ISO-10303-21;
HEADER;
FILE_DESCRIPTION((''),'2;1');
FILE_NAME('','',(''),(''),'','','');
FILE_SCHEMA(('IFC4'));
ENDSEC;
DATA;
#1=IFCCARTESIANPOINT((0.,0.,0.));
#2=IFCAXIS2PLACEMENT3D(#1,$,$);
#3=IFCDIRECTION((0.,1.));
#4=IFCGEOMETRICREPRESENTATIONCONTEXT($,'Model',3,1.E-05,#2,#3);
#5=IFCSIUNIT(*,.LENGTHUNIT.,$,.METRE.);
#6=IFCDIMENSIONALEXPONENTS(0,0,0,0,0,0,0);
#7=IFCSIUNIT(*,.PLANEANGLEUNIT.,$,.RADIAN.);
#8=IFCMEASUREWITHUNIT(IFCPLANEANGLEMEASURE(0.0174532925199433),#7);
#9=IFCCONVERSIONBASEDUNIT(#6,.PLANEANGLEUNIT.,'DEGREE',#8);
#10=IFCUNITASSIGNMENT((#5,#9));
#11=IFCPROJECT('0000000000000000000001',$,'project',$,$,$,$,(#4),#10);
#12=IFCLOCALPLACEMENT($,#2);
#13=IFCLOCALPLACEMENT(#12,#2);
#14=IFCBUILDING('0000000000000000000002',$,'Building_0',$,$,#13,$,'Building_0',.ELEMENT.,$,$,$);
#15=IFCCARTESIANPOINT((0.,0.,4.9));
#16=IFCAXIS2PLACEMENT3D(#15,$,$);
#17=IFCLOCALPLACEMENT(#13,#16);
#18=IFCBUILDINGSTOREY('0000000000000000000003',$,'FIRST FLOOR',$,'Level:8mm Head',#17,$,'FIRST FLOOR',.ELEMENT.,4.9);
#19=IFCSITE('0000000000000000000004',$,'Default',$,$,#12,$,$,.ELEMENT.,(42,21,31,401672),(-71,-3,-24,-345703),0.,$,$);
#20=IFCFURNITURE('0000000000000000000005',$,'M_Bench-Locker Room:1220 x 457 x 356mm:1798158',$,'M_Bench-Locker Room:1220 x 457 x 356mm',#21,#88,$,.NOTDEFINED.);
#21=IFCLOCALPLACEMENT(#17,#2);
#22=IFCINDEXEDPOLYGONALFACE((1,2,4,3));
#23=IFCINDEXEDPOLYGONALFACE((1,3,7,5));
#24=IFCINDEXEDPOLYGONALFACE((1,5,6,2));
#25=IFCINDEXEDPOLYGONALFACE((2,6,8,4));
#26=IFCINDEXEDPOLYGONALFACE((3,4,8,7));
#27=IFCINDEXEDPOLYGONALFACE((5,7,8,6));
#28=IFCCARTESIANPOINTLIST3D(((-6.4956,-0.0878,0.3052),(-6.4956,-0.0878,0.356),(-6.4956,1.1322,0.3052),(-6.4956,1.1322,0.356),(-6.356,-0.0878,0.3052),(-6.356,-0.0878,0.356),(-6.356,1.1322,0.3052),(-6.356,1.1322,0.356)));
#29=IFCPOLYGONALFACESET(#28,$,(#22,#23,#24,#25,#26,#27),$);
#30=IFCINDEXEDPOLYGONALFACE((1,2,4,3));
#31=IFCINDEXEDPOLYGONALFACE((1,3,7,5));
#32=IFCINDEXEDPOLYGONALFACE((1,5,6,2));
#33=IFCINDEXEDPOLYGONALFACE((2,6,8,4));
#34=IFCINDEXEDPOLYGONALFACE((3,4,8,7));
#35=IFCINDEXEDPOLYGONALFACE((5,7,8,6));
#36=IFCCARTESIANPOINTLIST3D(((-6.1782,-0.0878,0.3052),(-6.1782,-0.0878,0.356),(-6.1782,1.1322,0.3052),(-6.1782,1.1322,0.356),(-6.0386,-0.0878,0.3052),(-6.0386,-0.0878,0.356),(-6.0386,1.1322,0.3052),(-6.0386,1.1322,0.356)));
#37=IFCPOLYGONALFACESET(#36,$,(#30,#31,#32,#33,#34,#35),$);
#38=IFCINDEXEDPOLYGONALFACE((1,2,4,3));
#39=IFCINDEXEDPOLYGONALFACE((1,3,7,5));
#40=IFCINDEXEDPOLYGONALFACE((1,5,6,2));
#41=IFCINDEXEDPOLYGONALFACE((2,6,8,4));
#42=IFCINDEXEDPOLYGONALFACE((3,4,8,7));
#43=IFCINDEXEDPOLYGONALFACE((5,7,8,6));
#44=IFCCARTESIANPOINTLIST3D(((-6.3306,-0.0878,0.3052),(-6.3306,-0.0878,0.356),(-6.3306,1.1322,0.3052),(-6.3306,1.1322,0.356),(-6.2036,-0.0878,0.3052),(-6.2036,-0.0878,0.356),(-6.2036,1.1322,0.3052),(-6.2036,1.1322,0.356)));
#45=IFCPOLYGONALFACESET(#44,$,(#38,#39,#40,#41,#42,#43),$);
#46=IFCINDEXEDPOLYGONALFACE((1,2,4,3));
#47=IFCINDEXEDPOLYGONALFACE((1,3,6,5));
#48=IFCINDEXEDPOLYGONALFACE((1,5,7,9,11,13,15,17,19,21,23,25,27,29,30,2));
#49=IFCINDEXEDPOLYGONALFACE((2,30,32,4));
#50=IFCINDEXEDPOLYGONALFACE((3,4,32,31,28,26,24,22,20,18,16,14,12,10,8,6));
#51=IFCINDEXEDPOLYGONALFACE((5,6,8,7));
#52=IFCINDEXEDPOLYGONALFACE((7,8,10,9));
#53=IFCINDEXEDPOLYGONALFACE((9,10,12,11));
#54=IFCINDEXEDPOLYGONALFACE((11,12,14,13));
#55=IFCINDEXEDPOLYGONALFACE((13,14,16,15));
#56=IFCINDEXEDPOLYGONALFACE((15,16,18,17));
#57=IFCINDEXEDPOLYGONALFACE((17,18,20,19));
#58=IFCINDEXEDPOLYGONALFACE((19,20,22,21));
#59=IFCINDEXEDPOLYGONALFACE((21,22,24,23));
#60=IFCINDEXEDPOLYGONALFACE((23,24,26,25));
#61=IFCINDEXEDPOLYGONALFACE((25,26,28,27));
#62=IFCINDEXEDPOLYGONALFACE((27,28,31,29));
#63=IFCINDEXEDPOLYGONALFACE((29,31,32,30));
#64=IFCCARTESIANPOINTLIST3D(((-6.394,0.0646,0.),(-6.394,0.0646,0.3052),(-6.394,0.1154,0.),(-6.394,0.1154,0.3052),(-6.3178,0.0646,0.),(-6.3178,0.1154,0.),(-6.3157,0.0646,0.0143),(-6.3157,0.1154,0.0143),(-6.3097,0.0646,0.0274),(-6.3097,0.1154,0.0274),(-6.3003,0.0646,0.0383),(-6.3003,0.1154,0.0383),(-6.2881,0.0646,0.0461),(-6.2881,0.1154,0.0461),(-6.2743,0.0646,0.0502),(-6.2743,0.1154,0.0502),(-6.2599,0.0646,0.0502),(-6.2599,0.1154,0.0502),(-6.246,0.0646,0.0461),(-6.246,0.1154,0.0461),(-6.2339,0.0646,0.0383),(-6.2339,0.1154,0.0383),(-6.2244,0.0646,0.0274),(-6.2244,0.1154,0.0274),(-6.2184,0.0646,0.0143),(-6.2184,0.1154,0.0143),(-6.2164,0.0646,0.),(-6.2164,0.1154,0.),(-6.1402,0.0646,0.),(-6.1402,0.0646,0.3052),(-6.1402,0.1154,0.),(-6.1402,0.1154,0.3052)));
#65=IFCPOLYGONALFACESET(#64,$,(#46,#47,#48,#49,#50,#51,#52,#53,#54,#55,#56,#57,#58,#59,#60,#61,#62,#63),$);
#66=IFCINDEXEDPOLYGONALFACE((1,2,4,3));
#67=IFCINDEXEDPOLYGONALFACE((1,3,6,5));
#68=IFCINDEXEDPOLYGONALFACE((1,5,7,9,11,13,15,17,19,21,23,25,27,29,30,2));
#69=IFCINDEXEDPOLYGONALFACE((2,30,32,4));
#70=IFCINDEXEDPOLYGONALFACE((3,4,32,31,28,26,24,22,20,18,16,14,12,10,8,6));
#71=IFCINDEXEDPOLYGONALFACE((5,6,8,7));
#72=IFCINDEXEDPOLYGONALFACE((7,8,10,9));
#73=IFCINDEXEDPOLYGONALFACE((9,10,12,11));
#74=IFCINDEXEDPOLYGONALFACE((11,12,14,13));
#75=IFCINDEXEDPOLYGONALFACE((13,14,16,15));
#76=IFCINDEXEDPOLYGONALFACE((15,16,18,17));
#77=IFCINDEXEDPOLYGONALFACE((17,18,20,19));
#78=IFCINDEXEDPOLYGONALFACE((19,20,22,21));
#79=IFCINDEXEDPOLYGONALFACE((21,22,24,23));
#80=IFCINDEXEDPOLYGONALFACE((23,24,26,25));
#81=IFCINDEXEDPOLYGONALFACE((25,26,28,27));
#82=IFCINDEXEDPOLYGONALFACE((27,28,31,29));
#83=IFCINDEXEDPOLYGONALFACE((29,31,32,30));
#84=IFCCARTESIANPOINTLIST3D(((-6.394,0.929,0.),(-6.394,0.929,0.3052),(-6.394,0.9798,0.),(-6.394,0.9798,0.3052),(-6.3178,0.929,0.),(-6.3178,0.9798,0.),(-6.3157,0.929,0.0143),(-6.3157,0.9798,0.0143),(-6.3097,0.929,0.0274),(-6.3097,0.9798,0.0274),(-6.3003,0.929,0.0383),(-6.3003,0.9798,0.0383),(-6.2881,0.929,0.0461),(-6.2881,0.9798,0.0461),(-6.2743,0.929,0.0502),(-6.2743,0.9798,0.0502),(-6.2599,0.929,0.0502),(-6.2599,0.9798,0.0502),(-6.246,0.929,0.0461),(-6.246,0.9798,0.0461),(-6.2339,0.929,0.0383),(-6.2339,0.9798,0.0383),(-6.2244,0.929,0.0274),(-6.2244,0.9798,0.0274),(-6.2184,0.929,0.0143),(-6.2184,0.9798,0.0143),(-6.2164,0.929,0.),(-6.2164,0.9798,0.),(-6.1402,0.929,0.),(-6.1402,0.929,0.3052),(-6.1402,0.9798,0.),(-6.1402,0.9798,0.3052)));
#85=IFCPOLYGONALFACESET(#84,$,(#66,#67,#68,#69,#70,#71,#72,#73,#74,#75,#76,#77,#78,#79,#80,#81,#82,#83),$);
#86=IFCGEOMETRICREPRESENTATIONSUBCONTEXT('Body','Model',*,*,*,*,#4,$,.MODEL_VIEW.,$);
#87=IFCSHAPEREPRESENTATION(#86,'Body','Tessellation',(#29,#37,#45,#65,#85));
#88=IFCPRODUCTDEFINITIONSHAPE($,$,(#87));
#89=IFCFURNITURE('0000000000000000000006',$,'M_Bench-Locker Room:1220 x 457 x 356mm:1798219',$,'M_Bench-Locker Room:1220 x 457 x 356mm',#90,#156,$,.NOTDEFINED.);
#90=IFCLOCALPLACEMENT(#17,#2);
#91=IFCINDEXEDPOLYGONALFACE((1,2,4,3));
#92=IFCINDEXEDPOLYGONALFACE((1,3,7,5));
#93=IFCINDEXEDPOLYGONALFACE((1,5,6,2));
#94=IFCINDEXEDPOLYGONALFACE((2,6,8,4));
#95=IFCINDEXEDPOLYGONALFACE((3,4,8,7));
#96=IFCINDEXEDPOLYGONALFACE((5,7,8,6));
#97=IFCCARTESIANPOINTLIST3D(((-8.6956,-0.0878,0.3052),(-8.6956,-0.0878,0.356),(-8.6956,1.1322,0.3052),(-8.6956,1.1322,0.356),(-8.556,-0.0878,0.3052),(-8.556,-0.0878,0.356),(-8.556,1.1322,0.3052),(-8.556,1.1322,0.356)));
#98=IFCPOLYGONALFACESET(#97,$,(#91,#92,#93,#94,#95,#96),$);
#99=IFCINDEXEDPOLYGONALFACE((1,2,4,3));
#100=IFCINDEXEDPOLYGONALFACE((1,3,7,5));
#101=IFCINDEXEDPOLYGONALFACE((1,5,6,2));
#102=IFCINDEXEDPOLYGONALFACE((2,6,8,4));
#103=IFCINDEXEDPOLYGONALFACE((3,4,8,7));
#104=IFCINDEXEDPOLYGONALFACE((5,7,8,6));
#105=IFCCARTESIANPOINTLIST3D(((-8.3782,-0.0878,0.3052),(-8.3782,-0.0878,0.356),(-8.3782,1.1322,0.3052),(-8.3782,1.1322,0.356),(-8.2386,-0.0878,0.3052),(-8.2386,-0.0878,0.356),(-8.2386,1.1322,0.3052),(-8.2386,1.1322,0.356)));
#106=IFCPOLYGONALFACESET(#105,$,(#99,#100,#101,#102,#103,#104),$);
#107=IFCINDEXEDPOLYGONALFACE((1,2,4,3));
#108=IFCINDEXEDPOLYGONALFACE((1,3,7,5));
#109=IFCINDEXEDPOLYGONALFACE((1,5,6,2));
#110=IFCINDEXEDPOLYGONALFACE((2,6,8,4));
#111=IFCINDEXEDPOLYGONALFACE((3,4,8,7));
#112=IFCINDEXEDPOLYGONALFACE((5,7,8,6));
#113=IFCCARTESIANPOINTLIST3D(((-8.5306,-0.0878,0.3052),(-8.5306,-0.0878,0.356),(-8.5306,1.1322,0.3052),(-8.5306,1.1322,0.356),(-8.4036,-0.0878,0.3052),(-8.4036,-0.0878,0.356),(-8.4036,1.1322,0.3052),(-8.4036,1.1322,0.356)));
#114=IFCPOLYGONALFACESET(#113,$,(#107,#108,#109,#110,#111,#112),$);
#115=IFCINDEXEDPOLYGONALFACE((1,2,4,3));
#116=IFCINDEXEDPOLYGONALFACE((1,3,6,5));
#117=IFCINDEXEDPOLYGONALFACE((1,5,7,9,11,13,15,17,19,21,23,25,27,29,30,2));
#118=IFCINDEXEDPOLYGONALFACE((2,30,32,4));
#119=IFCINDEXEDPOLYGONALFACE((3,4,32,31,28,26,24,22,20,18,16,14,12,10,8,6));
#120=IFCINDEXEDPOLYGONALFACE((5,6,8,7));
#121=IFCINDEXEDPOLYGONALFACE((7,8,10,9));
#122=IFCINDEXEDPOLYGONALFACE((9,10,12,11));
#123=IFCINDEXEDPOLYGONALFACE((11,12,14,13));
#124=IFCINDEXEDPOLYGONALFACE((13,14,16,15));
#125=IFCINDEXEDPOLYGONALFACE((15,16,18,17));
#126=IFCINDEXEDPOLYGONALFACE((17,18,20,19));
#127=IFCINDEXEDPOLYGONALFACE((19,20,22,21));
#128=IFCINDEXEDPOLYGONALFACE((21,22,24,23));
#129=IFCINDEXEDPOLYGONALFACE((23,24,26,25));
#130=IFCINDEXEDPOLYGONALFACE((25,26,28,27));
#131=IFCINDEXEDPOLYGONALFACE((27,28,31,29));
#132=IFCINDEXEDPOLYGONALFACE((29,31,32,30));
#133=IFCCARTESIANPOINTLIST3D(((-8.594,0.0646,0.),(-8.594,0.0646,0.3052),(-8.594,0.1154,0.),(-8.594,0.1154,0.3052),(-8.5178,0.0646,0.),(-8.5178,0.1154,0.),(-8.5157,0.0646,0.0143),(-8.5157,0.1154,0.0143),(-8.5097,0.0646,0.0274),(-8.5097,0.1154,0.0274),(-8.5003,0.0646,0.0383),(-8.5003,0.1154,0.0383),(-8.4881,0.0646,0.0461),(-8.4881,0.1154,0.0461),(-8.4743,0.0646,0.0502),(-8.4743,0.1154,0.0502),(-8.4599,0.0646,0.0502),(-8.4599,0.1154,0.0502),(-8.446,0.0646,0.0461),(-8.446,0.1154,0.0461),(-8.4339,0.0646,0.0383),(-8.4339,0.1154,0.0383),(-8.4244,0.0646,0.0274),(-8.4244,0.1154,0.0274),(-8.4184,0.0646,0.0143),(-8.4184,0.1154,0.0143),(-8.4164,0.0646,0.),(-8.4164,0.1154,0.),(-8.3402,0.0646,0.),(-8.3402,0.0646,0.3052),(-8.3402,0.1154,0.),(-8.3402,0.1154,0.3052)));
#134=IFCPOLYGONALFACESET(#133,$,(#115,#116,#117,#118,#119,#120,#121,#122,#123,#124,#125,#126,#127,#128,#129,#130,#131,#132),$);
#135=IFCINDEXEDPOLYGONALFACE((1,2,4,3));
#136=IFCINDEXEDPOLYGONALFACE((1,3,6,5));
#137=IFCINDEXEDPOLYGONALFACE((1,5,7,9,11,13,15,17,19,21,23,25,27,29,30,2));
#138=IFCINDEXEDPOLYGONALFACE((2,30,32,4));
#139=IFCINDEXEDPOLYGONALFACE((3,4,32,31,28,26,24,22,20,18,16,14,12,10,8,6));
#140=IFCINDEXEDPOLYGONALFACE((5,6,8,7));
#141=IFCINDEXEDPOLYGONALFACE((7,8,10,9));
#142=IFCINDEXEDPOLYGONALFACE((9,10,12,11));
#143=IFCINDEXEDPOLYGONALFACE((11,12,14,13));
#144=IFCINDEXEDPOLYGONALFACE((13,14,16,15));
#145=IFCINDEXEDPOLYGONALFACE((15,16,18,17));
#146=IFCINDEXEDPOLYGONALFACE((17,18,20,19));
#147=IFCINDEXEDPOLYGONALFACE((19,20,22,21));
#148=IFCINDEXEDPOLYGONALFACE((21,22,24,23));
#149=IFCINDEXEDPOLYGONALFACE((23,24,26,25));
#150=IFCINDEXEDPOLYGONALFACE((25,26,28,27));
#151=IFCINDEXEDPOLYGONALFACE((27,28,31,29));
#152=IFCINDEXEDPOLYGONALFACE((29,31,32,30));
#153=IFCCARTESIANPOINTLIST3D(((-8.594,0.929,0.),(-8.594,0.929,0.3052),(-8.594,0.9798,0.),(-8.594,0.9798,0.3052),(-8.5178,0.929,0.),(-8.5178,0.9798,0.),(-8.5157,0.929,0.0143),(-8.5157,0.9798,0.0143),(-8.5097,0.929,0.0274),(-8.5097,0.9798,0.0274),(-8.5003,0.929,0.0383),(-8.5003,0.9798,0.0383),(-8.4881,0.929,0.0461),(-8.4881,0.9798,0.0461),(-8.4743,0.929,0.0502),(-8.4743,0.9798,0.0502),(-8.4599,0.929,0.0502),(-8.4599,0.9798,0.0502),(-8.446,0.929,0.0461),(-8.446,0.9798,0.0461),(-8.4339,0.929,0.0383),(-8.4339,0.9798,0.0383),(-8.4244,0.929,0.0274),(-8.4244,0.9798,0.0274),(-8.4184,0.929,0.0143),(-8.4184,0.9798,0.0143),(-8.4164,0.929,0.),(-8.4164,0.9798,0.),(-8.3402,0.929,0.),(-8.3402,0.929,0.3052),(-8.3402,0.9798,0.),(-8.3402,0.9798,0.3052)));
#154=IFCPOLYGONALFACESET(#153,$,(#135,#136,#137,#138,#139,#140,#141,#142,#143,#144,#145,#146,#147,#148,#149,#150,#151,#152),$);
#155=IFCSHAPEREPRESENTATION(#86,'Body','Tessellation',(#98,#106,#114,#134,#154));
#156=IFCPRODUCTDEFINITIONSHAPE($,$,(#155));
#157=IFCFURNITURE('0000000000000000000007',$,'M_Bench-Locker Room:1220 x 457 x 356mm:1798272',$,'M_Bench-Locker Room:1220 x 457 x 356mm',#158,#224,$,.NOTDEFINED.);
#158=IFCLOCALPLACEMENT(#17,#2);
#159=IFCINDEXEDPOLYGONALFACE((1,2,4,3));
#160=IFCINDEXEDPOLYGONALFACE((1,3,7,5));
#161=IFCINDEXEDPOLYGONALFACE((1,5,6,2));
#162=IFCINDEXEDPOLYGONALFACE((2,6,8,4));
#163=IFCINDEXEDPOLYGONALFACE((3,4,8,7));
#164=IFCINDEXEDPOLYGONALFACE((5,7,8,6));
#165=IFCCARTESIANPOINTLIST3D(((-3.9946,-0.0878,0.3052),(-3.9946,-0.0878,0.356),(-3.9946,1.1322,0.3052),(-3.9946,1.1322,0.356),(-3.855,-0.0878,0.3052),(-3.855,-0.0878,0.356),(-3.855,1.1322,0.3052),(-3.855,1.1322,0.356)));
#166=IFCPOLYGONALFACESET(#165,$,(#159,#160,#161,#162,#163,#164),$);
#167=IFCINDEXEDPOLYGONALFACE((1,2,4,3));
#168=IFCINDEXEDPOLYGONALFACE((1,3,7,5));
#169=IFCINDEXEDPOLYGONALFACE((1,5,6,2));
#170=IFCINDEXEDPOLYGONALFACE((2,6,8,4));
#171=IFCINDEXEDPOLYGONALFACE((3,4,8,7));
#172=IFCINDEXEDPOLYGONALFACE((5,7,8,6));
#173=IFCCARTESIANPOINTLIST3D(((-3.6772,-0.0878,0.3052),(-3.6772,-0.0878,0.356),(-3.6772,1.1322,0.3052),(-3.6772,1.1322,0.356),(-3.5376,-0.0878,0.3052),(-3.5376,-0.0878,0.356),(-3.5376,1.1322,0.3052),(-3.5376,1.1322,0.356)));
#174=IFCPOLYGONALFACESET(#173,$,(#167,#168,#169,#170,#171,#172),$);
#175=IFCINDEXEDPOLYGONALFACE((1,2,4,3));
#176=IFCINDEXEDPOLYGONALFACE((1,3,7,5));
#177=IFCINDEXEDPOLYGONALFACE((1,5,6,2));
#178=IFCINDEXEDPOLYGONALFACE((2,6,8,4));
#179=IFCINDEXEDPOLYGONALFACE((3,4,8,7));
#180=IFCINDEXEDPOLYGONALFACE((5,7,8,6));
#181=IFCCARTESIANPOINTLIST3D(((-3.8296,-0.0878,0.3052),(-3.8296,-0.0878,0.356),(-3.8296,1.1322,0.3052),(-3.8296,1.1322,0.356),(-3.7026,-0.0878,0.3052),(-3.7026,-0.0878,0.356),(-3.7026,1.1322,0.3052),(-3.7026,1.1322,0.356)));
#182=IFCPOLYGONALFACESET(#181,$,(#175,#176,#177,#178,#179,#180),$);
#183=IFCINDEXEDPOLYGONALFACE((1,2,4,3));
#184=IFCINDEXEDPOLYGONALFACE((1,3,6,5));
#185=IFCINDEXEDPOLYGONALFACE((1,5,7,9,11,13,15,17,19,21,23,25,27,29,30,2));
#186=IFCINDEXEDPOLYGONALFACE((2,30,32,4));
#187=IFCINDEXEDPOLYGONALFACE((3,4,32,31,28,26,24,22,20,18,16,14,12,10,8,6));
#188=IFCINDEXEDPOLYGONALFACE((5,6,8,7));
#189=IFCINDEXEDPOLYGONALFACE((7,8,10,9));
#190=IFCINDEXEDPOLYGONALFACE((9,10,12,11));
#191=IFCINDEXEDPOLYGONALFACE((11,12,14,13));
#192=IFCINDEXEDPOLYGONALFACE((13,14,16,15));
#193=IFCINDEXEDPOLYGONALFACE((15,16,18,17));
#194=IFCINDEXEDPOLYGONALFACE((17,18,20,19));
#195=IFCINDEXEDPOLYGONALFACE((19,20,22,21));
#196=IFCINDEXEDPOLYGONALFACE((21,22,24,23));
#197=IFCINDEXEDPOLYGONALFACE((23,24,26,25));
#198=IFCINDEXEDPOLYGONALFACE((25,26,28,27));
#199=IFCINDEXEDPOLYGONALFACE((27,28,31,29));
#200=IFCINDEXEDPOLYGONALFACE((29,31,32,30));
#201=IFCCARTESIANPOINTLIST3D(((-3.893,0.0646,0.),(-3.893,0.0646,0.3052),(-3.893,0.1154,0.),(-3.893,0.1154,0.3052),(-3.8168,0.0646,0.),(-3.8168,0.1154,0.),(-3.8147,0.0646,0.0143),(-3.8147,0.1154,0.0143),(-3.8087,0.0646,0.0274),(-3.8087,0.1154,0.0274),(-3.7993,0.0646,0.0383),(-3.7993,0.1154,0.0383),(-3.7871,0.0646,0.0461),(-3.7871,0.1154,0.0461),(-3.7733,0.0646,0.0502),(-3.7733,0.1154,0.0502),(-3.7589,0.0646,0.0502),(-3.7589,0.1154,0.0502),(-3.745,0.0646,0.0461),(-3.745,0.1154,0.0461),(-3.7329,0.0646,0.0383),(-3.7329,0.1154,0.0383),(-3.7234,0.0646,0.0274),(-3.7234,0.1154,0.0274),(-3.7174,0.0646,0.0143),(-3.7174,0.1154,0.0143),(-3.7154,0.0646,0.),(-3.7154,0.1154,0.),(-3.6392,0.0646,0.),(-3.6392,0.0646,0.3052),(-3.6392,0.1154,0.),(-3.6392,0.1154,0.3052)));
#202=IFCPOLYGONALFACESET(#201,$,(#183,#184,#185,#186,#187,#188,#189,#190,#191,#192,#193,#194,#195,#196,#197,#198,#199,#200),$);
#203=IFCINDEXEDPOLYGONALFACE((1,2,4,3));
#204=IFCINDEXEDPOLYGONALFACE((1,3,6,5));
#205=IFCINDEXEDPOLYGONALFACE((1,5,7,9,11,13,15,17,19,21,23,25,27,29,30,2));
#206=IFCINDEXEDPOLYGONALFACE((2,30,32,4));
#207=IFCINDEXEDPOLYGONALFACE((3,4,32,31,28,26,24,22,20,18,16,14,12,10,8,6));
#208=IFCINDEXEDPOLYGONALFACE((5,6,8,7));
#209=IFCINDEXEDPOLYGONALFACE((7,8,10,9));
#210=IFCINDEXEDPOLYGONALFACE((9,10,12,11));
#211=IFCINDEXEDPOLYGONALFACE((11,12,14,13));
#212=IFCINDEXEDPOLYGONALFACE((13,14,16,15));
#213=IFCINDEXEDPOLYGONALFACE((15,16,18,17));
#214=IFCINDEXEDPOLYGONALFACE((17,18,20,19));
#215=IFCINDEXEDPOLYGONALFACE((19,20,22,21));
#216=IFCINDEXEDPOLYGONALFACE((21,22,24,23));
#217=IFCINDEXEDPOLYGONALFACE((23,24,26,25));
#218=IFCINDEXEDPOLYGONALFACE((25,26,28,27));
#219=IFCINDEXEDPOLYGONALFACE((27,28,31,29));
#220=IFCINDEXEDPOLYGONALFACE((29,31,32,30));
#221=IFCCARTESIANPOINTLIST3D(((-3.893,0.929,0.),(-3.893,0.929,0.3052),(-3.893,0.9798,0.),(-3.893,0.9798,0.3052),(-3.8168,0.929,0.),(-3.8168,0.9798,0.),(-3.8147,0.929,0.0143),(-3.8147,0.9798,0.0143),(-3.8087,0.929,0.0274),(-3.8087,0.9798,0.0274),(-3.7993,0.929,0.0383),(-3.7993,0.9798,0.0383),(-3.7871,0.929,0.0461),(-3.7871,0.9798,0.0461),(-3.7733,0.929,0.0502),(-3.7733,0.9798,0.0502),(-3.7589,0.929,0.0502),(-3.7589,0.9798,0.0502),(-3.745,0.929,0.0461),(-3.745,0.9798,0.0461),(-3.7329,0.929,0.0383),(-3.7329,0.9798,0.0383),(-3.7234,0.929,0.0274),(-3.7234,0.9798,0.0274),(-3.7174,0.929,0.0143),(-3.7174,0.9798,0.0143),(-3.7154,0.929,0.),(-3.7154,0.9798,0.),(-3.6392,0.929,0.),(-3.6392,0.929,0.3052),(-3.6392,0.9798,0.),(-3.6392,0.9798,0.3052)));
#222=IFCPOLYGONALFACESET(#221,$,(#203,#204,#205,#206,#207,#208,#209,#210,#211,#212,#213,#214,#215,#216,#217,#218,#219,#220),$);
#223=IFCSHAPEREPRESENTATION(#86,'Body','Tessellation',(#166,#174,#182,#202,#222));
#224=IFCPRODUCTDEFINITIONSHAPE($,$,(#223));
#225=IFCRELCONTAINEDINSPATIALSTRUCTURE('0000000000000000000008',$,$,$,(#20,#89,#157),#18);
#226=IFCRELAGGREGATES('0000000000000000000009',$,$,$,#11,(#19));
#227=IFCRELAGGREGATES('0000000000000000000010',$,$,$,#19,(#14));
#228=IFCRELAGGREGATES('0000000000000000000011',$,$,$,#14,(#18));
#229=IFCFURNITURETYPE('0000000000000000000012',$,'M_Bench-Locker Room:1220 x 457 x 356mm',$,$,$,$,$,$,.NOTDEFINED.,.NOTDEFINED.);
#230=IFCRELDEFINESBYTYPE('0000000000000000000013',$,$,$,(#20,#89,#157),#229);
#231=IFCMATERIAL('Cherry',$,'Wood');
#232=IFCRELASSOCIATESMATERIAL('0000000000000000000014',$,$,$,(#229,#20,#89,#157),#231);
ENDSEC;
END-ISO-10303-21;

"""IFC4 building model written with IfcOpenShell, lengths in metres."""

from ifc_helpers import new_model, entity, si_unit, converted_unit, direction, frame, origin, place, context, subcontext, project, spatial, line, arc, indexed_curve, outline, extrude, source, transform, mapped, material, type_object, type_shapes, element, save


model = new_model("IFC4")

# Units and contexts
model_context = context("Model", 3, precision=1e-05, world=origin(), true_north=direction((0.0, 1.0)))
body_context = subcontext(model_context, "Body", "Model", "MODEL_VIEW")
ifc_project = project(units=[si_unit("LENGTHUNIT", "METRE"), converted_unit("PLANEANGLEUNIT", "DEGREE", entity("IfcPlaneAngleMeasure", 0.0174532925199433), si_unit("PLANEANGLEUNIT", "RADIAN"), dimensions=[0, 0, 0, 0, 0, 0, 0])], contexts=[model_context])

# Site, building, storey
site_placement = place(None, origin())
site = spatial("IfcSite", under=ifc_project, at=site_placement, Name="Default", CompositionType="ELEMENT", RefLatitude=(42, 21, 31, 401672), RefLongitude=(-71, -3, -24, -345703), RefElevation=0.0)
building_placement = place(site_placement, origin())
building = spatial("IfcBuilding", under=site, at=building_placement, Name="Building_0", LongName="Building_0", CompositionType="ELEMENT")
storey_placement = place(building_placement, frame((0.0, 0.0, 4.9)))
storey = spatial("IfcBuildingStorey", under=building, at=storey_placement, Name="FIRST FLOOR", ObjectType="Level:8mm Head", LongName="FIRST FLOOR", CompositionType="ELEMENT", Elevation=4.9)

# Furniture
ifc_material_1 = material(Name="Cherry", Category="Wood")
furniture_type = type_object("IfcFurnitureType", Name="M_Bench-Locker Room:1220 x 457 x 356mm", AssemblyPlace="NOTDEFINED", PredefinedType="NOTDEFINED", material=ifc_material_1)
shared_shape_1 = source(origin(), body_context, "Body", "SweptSolid", [
    extrude(outline(indexed_curve([(-0.61, -0.0698), (0.61, -0.0698), (0.61, 0.0698), (-0.61, 0.0698), (-0.61, -0.0698)], self_intersect=False)), frame((-0.1553, -0.022, 0.3052), z_axis=(0.0, 0.0, 1.0), x_axis=(-1.0, 0.0, 0.0)), (0.0, 0.0, 1.0), 0.0508),
    extrude(outline(indexed_curve([(-0.0698, -0.61), (0.0698, -0.61), (0.0698, 0.61), (-0.0698, 0.61), (-0.0698, -0.61)], self_intersect=False)), frame((-0.1553, -0.3394, 0.3052), z_axis=(0.0, 0.0, 1.0), x_axis=(0.0, 1.0, 0.0)), (0.0, 0.0, 1.0), 0.0508),
    extrude(outline(indexed_curve([(-0.61, -0.0635), (0.61, -0.0635), (0.61, 0.0635), (-0.61, 0.0635), (-0.61, -0.0635)], self_intersect=False)), frame((-0.1553, -0.1807, 0.3052), z_axis=(0.0, 0.0, 1.0), x_axis=(-1.0, 0.0, 0.0)), (0.0, 0.0, 1.0), 0.0508),
    extrude(outline(indexed_curve([(-0.1017, -0.1269), (0.2035, -0.1269), (0.2035, 0.1269), (-0.1017, 0.1269), (-0.1017, 0.0507), (-0.051, 0.0), (-0.1017, -0.0507)], segments=[line(1, 2, 3, 4, 5), arc(5, 6, 7), line(7, 1)], self_intersect=False)), frame((-0.6129, -0.1807, 0.1017), z_axis=(1.0, 0.0, 0.0), x_axis=(0.0, 0.0, 1.0)), (0.0, 0.0, 1.0), 0.0508),
    extrude(outline(indexed_curve([(-0.1269, 0.1017), (-0.1269, -0.2035), (0.1269, -0.2035), (0.1269, 0.1017), (0.0507, 0.1017), (0.0, 0.051), (-0.0507, 0.1017)], segments=[line(1, 2, 3, 4, 5), arc(5, 6, 7), line(7, 1)], self_intersect=False)), frame((0.2515, -0.1807, 0.1017), z_axis=(-1.0, 0.0, 0.0), x_axis=(0.0, 1.0, 0.0)), (0.0, 0.0, -1.0), 0.0508),
])
type_shapes(furniture_type, [shared_shape_1])
for number, where, z_axis, x_axis, name in (
    (1, (-6.4478, 0.6775, 0.0), (0.0, 0.0, 1.0), (0.0, 1.0, 0.0), "M_Bench-Locker Room:1220 x 457 x 356mm:1798158"),
    (2, (-8.6478, 0.6775, 0.0), (0.0, 0.0, 1.0), (0.0, 1.0, 0.0), "M_Bench-Locker Room:1220 x 457 x 356mm:1798219"),
    (3, (-3.9468, 0.6775, 0.0), (0.0, 0.0, 1.0), (0.0, 1.0, 0.0), "M_Bench-Locker Room:1220 x 457 x 356mm:1798272"),
):
    element("IfcFurniture", number, at=place(storey_placement, frame(where, z_axis=z_axis, x_axis=x_axis)), inside=storey, type_object=furniture_type, material=ifc_material_1, Name=name, ObjectType="M_Bench-Locker Room:1220 x 457 x 356mm", PredefinedType="NOTDEFINED", context=body_context, shape_type="MappedRepresentation", body=[
        mapped(shared_shape_1, transform((0.0, 0.0, 0.0), scale=1.0)),
    ])

save(model, "model.ifc")
